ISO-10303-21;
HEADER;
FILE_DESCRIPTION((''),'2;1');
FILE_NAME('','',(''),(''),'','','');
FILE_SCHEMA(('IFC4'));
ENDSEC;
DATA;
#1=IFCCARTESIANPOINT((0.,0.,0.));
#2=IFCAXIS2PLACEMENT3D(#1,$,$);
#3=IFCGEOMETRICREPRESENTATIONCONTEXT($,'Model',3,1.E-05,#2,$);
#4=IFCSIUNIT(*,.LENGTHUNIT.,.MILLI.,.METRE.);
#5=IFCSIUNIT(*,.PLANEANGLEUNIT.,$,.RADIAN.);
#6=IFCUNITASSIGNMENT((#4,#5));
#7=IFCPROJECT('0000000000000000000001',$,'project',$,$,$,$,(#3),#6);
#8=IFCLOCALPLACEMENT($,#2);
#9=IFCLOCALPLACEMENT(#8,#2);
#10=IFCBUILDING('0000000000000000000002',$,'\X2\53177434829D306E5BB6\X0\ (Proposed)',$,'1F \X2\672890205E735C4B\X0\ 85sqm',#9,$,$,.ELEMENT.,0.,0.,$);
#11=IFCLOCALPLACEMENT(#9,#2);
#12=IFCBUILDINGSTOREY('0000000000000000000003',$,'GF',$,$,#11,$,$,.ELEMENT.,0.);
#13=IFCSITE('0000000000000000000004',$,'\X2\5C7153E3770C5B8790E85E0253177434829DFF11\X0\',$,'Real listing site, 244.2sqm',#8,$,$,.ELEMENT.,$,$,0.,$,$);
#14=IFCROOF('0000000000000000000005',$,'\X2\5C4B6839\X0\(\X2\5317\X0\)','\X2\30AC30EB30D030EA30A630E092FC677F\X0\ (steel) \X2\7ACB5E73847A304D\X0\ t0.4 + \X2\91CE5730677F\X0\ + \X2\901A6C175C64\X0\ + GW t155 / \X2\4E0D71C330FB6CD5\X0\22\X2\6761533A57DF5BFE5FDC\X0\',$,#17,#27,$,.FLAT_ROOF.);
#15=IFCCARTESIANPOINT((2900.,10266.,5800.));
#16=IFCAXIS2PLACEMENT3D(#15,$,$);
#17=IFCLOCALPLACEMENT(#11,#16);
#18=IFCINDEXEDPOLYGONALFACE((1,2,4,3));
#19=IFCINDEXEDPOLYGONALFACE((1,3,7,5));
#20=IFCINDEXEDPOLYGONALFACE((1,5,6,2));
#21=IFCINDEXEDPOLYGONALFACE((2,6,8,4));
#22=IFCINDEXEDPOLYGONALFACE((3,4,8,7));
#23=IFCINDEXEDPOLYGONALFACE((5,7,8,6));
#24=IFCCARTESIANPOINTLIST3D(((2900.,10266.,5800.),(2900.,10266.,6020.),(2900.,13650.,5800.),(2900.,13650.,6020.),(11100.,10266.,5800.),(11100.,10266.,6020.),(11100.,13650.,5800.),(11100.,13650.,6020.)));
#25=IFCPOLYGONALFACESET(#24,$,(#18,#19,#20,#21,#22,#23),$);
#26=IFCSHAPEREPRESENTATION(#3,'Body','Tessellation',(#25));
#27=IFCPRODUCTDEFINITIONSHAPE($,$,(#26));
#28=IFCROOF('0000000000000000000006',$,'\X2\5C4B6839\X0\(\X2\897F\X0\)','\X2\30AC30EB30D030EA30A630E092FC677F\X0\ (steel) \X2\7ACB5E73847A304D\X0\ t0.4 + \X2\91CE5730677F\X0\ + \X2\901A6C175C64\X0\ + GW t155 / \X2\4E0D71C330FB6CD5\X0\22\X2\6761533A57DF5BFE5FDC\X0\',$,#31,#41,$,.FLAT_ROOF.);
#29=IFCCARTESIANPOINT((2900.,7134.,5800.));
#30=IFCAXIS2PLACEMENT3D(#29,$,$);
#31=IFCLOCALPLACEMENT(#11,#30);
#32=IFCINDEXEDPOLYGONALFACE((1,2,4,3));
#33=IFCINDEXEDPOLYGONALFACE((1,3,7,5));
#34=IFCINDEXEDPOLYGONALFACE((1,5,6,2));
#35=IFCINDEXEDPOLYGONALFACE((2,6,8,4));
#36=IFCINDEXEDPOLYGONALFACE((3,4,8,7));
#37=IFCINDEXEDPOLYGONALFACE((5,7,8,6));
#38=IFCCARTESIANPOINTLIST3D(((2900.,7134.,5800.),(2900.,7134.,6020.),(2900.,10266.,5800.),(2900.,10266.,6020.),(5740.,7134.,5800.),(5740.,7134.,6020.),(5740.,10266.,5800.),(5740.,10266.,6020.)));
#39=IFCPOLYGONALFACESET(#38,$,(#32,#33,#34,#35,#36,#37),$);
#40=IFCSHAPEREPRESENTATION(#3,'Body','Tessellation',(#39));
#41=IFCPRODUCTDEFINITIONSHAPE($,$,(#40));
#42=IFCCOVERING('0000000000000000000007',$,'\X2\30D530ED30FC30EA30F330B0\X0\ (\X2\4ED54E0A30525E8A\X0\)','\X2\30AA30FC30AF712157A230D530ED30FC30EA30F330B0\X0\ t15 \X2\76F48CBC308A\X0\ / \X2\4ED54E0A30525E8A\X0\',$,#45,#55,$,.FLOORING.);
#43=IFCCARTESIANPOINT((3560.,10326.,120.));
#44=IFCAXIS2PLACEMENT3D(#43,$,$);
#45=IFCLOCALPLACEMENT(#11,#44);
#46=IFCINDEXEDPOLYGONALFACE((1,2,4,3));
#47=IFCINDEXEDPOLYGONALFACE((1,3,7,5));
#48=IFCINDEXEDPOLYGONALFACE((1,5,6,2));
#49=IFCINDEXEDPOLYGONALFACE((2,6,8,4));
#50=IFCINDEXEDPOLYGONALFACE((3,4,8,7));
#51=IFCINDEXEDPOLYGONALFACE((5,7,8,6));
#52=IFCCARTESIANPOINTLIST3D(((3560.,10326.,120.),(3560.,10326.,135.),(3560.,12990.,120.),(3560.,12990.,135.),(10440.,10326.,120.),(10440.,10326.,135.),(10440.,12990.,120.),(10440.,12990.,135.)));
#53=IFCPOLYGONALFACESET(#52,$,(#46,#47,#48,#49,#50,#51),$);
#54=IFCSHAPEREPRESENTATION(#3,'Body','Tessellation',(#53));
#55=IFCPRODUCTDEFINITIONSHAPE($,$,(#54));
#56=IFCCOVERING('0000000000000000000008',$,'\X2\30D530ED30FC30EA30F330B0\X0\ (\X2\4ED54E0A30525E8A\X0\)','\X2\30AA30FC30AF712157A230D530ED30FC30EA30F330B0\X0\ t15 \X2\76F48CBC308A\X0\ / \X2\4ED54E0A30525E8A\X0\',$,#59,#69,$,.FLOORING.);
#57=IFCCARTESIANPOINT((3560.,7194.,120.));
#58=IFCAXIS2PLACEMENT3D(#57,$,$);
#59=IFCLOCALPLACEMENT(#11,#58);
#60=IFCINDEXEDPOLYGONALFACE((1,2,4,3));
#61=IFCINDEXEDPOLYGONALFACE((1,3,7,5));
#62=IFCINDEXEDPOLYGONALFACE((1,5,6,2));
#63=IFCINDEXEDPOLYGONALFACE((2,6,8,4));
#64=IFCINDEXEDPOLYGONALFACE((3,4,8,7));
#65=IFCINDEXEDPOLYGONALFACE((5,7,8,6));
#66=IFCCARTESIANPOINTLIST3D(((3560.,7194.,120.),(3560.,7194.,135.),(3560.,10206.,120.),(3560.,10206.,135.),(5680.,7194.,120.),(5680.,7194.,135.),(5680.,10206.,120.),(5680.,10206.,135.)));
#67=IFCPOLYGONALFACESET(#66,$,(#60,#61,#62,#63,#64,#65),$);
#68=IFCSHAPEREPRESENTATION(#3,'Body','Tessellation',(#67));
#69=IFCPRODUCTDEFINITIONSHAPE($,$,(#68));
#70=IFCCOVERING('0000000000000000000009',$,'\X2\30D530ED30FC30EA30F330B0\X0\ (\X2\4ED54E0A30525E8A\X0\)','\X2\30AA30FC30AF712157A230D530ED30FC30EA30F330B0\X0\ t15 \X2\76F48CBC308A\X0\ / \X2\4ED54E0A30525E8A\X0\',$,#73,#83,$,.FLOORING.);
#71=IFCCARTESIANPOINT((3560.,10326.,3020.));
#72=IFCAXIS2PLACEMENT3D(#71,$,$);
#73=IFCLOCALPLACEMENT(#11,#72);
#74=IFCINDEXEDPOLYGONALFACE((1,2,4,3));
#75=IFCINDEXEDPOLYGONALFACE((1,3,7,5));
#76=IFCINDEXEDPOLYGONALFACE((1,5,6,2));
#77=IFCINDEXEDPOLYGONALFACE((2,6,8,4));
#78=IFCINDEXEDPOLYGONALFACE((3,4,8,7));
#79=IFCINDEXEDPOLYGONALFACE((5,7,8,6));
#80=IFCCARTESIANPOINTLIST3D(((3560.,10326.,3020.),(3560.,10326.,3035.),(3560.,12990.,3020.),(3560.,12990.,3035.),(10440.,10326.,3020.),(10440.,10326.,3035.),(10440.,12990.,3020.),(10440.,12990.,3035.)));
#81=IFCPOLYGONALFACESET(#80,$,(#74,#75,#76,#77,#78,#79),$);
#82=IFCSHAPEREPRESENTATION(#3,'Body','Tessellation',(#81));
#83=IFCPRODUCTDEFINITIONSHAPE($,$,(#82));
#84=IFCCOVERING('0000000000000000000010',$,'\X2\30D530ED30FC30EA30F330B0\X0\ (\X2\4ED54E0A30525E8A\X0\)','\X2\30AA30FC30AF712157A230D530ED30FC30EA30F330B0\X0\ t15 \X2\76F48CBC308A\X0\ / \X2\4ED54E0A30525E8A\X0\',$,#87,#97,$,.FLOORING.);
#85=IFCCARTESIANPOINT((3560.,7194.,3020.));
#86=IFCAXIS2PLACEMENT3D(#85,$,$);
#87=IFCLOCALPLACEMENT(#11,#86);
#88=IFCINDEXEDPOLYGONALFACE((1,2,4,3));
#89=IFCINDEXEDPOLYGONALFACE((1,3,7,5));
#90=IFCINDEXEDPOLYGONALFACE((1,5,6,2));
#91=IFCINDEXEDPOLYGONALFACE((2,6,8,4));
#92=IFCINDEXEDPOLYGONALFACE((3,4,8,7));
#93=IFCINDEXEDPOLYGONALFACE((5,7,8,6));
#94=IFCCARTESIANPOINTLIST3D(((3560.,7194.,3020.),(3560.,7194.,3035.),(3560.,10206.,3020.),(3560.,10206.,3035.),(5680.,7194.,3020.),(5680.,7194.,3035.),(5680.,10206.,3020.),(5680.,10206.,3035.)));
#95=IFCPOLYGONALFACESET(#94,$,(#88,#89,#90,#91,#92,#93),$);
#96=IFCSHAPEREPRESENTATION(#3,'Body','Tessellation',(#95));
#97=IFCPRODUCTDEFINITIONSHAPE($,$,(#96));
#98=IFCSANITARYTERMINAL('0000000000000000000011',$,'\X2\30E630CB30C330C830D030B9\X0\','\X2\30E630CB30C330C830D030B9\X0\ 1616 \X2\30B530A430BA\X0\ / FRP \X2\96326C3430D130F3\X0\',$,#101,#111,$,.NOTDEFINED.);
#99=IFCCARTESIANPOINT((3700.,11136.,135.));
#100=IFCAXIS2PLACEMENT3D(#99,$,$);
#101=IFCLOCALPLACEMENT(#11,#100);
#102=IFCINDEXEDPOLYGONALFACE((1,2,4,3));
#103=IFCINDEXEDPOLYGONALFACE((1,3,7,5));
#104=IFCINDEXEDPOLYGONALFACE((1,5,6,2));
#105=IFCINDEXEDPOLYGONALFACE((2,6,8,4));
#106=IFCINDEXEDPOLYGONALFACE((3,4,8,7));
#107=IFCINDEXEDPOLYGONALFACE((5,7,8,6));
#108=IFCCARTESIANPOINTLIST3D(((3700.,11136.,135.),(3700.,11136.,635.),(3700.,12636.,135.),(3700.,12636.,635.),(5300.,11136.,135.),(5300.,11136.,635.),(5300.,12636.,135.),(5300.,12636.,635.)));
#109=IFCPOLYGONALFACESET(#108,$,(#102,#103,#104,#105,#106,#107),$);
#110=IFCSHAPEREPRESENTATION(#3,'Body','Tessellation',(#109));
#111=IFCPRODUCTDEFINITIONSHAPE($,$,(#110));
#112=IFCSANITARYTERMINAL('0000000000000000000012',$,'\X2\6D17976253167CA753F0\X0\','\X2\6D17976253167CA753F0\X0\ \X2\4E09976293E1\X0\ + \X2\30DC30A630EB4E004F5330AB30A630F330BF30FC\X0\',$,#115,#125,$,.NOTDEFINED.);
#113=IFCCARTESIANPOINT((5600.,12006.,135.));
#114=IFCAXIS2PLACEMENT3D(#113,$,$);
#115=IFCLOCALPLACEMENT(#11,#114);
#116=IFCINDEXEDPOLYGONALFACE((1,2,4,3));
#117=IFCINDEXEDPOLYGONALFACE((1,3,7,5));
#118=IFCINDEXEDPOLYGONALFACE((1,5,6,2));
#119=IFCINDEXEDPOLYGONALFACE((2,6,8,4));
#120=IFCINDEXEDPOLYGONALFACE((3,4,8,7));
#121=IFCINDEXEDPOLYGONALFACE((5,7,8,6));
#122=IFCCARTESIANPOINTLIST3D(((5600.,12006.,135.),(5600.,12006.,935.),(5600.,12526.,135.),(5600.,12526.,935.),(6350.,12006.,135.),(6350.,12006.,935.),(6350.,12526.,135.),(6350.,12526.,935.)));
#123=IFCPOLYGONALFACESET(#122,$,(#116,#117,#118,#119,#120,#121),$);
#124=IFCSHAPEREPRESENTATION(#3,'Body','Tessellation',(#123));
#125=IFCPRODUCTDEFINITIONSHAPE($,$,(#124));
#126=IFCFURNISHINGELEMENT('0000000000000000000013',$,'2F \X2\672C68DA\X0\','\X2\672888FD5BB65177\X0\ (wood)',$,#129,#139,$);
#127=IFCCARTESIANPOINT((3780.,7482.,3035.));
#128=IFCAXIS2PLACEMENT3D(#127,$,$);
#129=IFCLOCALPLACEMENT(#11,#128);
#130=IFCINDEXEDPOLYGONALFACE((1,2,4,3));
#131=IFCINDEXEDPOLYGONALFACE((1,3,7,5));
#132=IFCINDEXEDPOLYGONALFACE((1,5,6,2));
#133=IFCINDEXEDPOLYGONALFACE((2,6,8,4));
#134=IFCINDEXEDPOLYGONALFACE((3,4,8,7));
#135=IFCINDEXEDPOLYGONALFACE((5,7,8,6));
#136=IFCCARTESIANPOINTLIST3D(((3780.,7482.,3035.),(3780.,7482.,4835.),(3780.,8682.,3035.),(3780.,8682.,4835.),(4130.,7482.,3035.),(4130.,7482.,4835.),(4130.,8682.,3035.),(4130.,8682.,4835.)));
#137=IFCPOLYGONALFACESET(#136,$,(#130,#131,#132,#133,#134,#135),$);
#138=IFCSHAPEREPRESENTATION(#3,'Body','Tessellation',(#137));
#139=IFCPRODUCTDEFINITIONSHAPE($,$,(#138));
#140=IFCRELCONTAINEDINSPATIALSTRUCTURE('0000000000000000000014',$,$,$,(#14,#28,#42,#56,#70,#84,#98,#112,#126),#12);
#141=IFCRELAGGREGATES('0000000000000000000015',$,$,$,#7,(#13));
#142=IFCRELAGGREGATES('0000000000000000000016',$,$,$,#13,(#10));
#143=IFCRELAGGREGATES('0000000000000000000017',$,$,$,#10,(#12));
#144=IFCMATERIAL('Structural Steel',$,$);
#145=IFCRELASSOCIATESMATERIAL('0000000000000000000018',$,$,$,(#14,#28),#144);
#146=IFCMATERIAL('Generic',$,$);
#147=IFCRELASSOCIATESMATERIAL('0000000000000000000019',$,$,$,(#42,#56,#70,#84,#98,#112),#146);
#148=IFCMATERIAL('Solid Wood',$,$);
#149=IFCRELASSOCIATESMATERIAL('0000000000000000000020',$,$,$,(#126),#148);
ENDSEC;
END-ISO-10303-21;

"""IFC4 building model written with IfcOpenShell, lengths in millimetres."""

from ifc_helpers import new_model, si_unit, frame, frame_2d, origin, place, context, project, spatial, rectangle, extrude, material, element, save


model = new_model("IFC4")

# Units and contexts
model_context = context("Model", 3, precision=1e-05, world=origin())
ifc_project = project(units=[si_unit("LENGTHUNIT", "METRE", prefix="MILLI"), si_unit("PLANEANGLEUNIT", "RADIAN")], contexts=[model_context])

# Site, building, storey
site_placement = place(None, origin())
site = spatial("IfcSite", under=ifc_project, at=site_placement, Name="山口県宇部市北琴芝１", ObjectType="Real listing site, 244.2sqm", CompositionType="ELEMENT", RefElevation=0.0)
building_placement = place(site_placement, origin())
building = spatial("IfcBuilding", under=site, at=building_placement, Name="北琴芝の家 (Proposed)", ObjectType="1F 木造平屋 85sqm", CompositionType="ELEMENT", ElevationOfRefHeight=0.0, ElevationOfTerrain=0.0)
storey_placement = place(building_placement, origin())
storey = spatial("IfcBuildingStorey", under=building, at=storey_placement, Name="GF", CompositionType="ELEMENT", Elevation=0.0)

# Shared definitions
ifc_material_1 = material(Name="Solid Wood")

# Roofs
ifc_material_2 = material(Name="Structural Steel")
for number, where, name in (
    (1, (2900.0, 10266.0, 5800.0), "屋根(北)"),
):
    element("IfcRoof", number, at=place(storey_placement, frame(where)), inside=storey, material=ifc_material_2, Name=name, Description="ガルバリウム鋼板 (steel) 立平葺き t0.4 + 野地板 + 通気層 + GW t155 / 不燃・法22条区域対応", PredefinedType="FLAT_ROOF", context=model_context, shape_type="SweptSolid", body=[
        extrude(rectangle(XDim=8200.0, YDim=3384.0, at=frame_2d((4100.0, 1692.0))), frame((2900.0, 10266.0, 5800.0)), (0.0, 0.0, 1.0), 220.0),
    ])
roof_placement = place(storey_placement, frame((2900.0, 7134.0, 5800.0)))
element("IfcRoof", 2, at=roof_placement, inside=storey, material=ifc_material_2, Name="屋根(西)", Description="ガルバリウム鋼板 (steel) 立平葺き t0.4 + 野地板 + 通気層 + GW t155 / 不燃・法22条区域対応", PredefinedType="FLAT_ROOF", context=model_context, shape_type="SweptSolid", body=[
    extrude(rectangle(XDim=2840.0, YDim=3132.0, at=frame_2d((1420.0, 1566.0))), frame((2900.0, 7134.0, 5800.0)), (0.0, 0.0, 1.0), 220.0),
])

# Coverings
ifc_material_3 = material(Name="Generic")
covering_1_placement = place(storey_placement, frame((3560.0, 10326.0, 120.0)))
element("IfcCovering", 3, at=covering_1_placement, inside=storey, material=ifc_material_3, Name="フローリング (仕上げ床)", Description="オーク無垢フローリング t15 直貼り / 仕上げ床", PredefinedType="FLOORING", context=model_context, shape_type="SweptSolid", body=[
    extrude(rectangle(XDim=6880.0, YDim=2664.0, at=frame_2d((3440.0, 1332.0))), frame((3560.0, 10326.0, 120.0)), (0.0, 0.0, 1.0), 15.0),
])
covering_2_placement = place(storey_placement, frame((3560.0, 7194.0, 120.0)))
element("IfcCovering", 4, at=covering_2_placement, inside=storey, material=ifc_material_3, Name="フローリング (仕上げ床)", Description="オーク無垢フローリング t15 直貼り / 仕上げ床", PredefinedType="FLOORING", context=model_context, shape_type="SweptSolid", body=[
    extrude(rectangle(XDim=2120.0, YDim=3012.0, at=frame_2d((1060.0, 1506.0))), frame((3560.0, 7194.0, 120.0)), (0.0, 0.0, 1.0), 15.0),
])
covering_3_placement = place(storey_placement, frame((3560.0, 10326.0, 3020.0)))
element("IfcCovering", 5, at=covering_3_placement, inside=storey, material=ifc_material_3, Name="フローリング (仕上げ床)", Description="オーク無垢フローリング t15 直貼り / 仕上げ床", PredefinedType="FLOORING", context=model_context, shape_type="SweptSolid", body=[
    extrude(rectangle(XDim=6880.0, YDim=2664.0, at=frame_2d((3440.0, 1332.0))), frame((3560.0, 10326.0, 3020.0)), (0.0, 0.0, 1.0), 15.0),
])
covering_4_placement = place(storey_placement, frame((3560.0, 7194.0, 3020.0)))
element("IfcCovering", 6, at=covering_4_placement, inside=storey, material=ifc_material_3, Name="フローリング (仕上げ床)", Description="オーク無垢フローリング t15 直貼り / 仕上げ床", PredefinedType="FLOORING", context=model_context, shape_type="SweptSolid", body=[
    extrude(rectangle(XDim=2120.0, YDim=3012.0, at=frame_2d((1060.0, 1506.0))), frame((3560.0, 7194.0, 3020.0)), (0.0, 0.0, 1.0), 15.0),
])

# Sanitary terminals
sanitary_terminal_1_placement = place(storey_placement, frame((3700.0, 11136.0, 135.0)))
element("IfcSanitaryTerminal", 7, at=sanitary_terminal_1_placement, inside=storey, material=ifc_material_3, Name="ユニットバス", Description="ユニットバス 1616 サイズ / FRP 防水パン", PredefinedType="NOTDEFINED", context=model_context, shape_type="SweptSolid", body=[
    extrude(rectangle(XDim=1600.0, YDim=1500.0, at=frame_2d((800.0, 750.0))), frame((3700.0, 11136.0, 135.0)), (0.0, 0.0, 1.0), 500.0),
])
sanitary_terminal_2_placement = place(storey_placement, frame((5600.0, 12006.0, 135.0)))
element("IfcSanitaryTerminal", 8, at=sanitary_terminal_2_placement, inside=storey, material=ifc_material_3, Name="洗面化粧台", Description="洗面化粧台 三面鏡 + ボウル一体カウンター", PredefinedType="NOTDEFINED", context=model_context, shape_type="SweptSolid", body=[
    extrude(rectangle(XDim=750.0, YDim=520.0, at=frame_2d((375.0, 260.0))), frame((5600.0, 12006.0, 135.0)), (0.0, 0.0, 1.0), 800.0),
])

# Furnishing element
furnishing_placement = place(storey_placement, frame((3780.0, 7482.0, 3035.0)))
element("IfcFurnishingElement", 9, at=furnishing_placement, inside=storey, material=ifc_material_1, Name="2F 本棚", Description="木製家具 (wood)", context=model_context, shape_type="SweptSolid", body=[
    extrude(rectangle(XDim=350.0, YDim=1200.0, at=frame_2d((175.0, 600.0))), frame((3780.0, 7482.0, 3035.0)), (0.0, 0.0, 1.0), 1800.0),
])

save(model, "model.ifc")
